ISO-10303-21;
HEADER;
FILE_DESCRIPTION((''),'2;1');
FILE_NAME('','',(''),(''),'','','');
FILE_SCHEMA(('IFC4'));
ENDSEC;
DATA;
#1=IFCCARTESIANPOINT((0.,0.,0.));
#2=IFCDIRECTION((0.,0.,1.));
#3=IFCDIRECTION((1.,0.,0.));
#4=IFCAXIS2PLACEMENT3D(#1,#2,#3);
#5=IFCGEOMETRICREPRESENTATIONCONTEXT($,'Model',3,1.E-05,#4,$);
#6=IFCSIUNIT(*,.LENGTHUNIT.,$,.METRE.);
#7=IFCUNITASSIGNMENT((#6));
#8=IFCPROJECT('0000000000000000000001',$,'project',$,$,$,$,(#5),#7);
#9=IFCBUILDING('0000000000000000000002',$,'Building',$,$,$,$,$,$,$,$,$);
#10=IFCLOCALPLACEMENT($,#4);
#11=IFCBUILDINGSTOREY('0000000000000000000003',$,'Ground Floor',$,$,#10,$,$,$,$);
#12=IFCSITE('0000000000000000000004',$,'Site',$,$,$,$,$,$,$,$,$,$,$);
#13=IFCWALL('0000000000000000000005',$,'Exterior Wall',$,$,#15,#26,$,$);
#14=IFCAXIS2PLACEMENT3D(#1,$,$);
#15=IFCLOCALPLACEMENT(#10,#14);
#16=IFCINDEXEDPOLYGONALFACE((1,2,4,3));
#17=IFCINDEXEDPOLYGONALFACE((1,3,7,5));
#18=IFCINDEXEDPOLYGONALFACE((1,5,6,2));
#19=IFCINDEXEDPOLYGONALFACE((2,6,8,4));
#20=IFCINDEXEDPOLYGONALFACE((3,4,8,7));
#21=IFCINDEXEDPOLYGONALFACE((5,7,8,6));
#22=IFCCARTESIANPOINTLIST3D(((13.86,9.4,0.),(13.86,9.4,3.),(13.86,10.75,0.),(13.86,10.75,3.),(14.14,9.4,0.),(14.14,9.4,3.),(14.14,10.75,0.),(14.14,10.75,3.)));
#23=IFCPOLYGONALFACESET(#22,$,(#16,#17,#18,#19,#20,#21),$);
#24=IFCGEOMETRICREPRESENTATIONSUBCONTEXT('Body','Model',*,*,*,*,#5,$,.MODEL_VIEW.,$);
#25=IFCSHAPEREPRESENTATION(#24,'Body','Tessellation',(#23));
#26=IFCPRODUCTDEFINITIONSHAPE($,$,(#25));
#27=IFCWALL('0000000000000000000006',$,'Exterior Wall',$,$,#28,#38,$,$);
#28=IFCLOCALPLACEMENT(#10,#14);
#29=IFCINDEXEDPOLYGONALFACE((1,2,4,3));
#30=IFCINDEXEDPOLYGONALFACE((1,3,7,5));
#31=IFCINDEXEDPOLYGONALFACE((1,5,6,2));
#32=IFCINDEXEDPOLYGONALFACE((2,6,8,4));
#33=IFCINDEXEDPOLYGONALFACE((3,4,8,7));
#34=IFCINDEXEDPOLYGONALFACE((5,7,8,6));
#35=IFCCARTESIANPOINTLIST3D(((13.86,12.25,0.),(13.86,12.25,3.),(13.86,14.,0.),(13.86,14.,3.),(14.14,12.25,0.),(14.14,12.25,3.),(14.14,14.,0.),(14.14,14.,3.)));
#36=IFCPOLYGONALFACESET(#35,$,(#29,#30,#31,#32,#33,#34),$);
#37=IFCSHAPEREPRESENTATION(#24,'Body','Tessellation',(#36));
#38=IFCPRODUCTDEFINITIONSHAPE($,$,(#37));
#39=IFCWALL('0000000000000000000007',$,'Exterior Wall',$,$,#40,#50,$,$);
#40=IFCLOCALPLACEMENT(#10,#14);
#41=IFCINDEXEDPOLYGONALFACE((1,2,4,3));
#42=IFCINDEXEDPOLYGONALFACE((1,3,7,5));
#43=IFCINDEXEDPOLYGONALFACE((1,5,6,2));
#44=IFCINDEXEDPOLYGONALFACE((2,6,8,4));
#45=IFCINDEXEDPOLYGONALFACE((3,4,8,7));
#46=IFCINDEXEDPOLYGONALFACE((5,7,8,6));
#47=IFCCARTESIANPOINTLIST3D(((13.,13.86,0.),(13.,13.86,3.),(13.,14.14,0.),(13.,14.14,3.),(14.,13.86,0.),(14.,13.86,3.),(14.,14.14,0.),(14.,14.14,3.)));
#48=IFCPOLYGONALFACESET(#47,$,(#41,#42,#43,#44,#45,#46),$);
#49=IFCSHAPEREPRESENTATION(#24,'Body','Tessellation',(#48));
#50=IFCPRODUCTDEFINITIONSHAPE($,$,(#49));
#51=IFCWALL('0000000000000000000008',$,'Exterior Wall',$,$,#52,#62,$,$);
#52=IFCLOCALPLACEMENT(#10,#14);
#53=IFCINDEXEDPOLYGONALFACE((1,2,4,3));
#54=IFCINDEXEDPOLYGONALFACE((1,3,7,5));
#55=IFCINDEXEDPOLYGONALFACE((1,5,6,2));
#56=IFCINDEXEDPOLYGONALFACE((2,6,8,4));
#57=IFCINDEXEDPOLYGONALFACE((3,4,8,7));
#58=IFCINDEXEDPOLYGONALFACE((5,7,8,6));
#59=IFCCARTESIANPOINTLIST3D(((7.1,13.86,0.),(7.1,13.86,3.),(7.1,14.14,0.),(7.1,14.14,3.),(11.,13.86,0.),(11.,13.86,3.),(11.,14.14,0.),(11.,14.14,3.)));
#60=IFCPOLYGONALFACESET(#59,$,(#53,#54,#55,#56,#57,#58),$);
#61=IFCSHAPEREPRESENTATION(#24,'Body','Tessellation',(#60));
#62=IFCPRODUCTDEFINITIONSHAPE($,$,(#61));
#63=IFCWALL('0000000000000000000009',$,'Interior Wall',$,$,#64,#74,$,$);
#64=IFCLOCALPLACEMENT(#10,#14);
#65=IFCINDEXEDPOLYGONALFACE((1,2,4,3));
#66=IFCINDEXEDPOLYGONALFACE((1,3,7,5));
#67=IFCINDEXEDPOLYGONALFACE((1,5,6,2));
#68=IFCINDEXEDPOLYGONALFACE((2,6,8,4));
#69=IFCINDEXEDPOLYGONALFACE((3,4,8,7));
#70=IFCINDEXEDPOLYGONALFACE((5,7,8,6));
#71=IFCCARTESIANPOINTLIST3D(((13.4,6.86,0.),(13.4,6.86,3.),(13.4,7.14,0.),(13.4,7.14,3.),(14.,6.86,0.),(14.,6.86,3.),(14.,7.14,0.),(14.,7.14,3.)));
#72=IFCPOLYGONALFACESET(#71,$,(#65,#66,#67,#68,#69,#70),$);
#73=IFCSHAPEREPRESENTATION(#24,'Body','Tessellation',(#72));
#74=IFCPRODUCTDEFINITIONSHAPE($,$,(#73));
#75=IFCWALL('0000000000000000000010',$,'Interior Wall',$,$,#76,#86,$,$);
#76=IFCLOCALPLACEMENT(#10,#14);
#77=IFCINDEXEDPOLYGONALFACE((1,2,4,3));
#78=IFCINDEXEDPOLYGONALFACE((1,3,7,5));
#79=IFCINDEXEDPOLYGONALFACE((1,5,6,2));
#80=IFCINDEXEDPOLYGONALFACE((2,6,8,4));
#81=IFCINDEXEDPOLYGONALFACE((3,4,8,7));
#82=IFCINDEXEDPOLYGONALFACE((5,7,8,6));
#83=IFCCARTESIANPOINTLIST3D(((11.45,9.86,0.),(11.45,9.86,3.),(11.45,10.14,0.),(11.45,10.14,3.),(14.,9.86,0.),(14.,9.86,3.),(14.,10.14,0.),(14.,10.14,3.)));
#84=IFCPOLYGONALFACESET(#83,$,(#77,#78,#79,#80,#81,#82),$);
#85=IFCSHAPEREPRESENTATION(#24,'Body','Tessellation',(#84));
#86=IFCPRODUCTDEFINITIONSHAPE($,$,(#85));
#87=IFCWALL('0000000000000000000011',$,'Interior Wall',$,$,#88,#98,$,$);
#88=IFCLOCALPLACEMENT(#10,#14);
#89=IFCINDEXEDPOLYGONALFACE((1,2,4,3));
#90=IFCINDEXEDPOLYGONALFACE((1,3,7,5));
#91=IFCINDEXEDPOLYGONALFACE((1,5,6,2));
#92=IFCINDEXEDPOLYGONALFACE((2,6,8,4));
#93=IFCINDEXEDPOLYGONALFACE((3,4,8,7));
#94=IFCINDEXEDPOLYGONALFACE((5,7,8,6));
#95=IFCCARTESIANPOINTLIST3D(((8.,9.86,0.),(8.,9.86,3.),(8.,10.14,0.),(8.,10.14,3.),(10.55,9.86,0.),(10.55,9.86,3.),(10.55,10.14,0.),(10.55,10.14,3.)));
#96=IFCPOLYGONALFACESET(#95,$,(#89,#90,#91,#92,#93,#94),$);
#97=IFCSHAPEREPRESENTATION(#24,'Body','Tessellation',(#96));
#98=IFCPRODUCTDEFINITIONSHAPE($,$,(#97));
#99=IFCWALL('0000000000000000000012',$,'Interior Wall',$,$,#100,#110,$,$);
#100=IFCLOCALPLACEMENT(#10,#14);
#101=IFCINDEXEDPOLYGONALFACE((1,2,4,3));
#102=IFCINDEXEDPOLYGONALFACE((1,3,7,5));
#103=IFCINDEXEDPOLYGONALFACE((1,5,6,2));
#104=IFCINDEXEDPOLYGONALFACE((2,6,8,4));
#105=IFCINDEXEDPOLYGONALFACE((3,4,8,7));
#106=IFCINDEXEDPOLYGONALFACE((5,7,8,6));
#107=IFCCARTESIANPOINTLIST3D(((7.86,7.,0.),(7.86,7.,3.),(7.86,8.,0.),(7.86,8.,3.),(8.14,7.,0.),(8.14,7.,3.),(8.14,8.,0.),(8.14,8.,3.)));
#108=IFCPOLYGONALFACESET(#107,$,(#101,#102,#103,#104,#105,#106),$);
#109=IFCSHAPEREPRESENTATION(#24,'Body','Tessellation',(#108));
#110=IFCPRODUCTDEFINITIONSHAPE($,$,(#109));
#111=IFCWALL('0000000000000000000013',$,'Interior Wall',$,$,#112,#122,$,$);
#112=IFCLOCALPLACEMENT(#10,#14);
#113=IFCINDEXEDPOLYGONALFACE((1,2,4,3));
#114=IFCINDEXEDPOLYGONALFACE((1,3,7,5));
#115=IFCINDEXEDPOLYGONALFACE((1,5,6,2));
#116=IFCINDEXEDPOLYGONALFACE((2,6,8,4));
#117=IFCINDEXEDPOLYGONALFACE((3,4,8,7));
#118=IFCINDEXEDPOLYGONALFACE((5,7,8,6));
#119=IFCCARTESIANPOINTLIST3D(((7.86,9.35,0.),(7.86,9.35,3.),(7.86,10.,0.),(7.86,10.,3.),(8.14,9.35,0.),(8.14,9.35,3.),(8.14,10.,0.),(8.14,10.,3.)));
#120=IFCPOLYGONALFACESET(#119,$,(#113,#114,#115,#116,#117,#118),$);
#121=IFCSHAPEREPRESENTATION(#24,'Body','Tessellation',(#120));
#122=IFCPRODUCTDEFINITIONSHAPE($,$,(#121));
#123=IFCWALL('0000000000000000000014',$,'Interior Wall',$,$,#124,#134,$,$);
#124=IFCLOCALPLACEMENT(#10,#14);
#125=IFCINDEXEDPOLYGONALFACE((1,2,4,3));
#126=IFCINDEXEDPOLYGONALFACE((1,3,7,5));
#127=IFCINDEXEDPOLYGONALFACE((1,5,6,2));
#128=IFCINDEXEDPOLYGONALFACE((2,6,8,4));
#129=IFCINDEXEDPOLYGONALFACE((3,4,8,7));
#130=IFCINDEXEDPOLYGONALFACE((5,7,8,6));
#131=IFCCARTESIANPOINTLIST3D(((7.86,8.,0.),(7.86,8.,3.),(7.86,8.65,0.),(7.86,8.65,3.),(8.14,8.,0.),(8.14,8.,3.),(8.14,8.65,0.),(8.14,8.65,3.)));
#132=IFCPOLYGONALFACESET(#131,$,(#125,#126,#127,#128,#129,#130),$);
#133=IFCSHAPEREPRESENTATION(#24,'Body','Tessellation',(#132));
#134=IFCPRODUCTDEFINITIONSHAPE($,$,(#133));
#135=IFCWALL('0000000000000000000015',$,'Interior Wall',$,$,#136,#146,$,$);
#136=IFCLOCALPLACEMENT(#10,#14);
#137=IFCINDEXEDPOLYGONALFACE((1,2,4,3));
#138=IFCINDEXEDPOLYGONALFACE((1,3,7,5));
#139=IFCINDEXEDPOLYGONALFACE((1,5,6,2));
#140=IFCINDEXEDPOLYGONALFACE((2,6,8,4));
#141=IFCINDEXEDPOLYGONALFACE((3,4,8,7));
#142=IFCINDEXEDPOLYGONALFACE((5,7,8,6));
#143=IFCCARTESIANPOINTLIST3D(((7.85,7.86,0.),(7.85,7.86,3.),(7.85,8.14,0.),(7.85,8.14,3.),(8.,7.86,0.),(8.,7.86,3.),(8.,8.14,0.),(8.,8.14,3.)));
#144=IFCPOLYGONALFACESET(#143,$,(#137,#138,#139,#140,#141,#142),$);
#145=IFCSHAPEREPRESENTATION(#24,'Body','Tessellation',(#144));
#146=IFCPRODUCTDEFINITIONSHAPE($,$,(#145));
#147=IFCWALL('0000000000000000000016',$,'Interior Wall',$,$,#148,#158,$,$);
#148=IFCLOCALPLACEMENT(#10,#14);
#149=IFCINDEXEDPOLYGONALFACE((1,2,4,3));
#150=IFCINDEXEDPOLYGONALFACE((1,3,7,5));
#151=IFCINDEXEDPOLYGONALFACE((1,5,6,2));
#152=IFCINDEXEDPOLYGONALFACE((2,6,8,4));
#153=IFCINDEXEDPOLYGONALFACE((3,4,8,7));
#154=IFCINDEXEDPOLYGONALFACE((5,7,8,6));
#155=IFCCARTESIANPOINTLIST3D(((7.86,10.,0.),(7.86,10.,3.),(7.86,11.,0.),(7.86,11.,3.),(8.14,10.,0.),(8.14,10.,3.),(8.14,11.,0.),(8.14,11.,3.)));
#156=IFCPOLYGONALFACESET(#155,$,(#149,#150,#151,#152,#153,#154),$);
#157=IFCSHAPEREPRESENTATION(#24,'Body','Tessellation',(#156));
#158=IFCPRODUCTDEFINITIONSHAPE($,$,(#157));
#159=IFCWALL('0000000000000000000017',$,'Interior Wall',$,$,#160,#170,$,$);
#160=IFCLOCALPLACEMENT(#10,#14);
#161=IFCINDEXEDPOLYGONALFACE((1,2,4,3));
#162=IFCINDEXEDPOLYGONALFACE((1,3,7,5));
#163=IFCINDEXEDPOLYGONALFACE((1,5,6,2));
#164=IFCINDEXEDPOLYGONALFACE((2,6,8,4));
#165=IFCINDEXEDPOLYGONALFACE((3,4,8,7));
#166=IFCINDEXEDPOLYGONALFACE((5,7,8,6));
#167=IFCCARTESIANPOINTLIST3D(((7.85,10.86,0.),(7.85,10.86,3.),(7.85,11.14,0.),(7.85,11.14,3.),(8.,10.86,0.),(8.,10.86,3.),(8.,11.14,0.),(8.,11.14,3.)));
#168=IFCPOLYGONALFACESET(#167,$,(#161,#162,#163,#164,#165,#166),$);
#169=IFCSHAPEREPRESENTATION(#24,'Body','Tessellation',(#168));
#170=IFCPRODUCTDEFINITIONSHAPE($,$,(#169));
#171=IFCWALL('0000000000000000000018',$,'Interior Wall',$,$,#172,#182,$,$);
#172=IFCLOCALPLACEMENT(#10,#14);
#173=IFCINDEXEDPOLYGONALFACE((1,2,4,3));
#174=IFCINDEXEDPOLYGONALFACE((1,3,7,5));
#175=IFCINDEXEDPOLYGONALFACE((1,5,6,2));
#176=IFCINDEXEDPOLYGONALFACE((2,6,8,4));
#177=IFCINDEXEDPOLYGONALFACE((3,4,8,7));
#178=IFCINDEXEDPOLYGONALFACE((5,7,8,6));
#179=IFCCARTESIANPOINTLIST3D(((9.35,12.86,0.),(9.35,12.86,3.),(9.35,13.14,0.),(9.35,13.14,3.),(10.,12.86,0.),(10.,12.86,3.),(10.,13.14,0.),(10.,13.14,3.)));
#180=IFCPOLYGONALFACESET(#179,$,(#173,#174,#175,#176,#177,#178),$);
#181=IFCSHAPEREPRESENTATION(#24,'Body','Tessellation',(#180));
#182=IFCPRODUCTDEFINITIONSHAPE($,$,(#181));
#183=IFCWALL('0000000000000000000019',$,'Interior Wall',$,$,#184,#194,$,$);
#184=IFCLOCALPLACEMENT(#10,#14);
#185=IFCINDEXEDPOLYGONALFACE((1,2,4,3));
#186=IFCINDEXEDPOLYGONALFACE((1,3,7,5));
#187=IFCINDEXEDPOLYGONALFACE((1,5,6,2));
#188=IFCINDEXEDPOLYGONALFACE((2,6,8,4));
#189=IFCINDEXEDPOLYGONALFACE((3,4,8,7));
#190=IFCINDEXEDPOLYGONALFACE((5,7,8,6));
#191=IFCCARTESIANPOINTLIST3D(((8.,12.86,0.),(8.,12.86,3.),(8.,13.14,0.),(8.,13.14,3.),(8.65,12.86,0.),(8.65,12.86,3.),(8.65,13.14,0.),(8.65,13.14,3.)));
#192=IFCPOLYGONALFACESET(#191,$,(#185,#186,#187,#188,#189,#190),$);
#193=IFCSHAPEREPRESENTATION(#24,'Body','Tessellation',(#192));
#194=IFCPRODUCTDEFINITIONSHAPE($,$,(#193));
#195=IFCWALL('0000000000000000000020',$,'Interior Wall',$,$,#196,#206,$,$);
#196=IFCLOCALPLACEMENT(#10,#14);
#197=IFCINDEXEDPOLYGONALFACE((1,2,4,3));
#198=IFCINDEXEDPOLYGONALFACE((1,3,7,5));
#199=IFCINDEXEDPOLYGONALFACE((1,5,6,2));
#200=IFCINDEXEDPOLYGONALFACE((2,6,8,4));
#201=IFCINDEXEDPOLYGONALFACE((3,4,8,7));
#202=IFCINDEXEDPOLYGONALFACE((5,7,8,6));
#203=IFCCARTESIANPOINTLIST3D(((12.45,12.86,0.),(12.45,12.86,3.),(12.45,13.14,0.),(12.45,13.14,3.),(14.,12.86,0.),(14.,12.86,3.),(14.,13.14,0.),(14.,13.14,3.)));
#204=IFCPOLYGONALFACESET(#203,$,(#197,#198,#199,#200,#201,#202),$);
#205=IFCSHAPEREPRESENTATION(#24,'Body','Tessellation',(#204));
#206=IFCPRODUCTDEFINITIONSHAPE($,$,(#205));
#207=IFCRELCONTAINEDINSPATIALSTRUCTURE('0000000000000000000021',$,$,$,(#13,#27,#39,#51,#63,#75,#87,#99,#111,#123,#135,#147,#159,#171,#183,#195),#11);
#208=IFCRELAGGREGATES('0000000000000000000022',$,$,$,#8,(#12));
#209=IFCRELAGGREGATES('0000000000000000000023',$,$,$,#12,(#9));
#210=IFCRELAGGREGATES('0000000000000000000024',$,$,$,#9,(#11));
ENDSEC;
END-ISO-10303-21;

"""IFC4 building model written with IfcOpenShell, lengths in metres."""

from ifc_helpers import new_model, si_unit, frame, origin_with_axes, place, context, subcontext, project, spatial, indexed_curve, outline, extrude, element, save


model = new_model("IFC4")

# Units and contexts
model_context = context("Model", 3, precision=1e-05, world=origin_with_axes())
body_context = subcontext(model_context, "Body", "Model", "MODEL_VIEW")
ifc_project = project(units=[si_unit("LENGTHUNIT", "METRE")], contexts=[model_context])

# Site, building, storey
site = spatial("IfcSite", under=ifc_project, Name="Site")
building = spatial("IfcBuilding", under=site, Name="Building")
storey_placement = place(None, origin_with_axes())
storey = spatial("IfcBuildingStorey", under=building, at=storey_placement, Name="Ground Floor")

# Walls
wall_1_placement = place(storey_placement, frame((14.0, 9.4, 0.0), z_axis=(0.0, 0.0, 1.0), x_axis=(0.0, 1.0, 0.0)))
element("IfcWall", 1, at=wall_1_placement, inside=storey, Name="Exterior Wall", context=body_context, shape_type="SweptSolid", body=[
    extrude(outline(indexed_curve([(0.0, 0.0), (0.0, 0.28), (1.35, 0.28), (1.35, 0.0), (0.0, 0.0)], self_intersect=False)), frame((0.0, -0.14, 0.0), z_axis=(0.0, 0.0, 1.0), x_axis=(1.0, 0.0, 0.0)), (0.0, 0.0, 1.0), 3.0),
])
wall_2_placement = place(storey_placement, frame((14.0, 12.25, 0.0), z_axis=(0.0, 0.0, 1.0), x_axis=(0.0, 1.0, 0.0)))
element("IfcWall", 2, at=wall_2_placement, inside=storey, Name="Exterior Wall", context=body_context, shape_type="SweptSolid", body=[
    extrude(outline(indexed_curve([(0.0, 0.0), (0.0, 0.28), (1.75, 0.28), (1.75, 0.0), (0.0, 0.0)], self_intersect=False)), frame((0.0, -0.14, 0.0), z_axis=(0.0, 0.0, 1.0), x_axis=(1.0, 0.0, 0.0)), (0.0, 0.0, 1.0), 3.0),
])
wall_3_placement = place(storey_placement, frame((14.0, 14.0, 0.0), z_axis=(0.0, 0.0, 1.0), x_axis=(-1.0, 0.0, 0.0)))
element("IfcWall", 3, at=wall_3_placement, inside=storey, Name="Exterior Wall", context=body_context, shape_type="SweptSolid", body=[
    extrude(outline(indexed_curve([(0.0, 0.0), (0.0, 0.28), (1.0, 0.28), (1.0, 0.0), (0.0, 0.0)], self_intersect=False)), frame((0.0, -0.14, 0.0), z_axis=(0.0, 0.0, 1.0), x_axis=(1.0, 0.0, 0.0)), (0.0, 0.0, 1.0), 3.0),
])
wall_4_placement = place(storey_placement, frame((11.0, 14.0, 0.0), z_axis=(0.0, 0.0, 1.0), x_axis=(-1.0, 0.0, 0.0)))
element("IfcWall", 4, at=wall_4_placement, inside=storey, Name="Exterior Wall", context=body_context, shape_type="SweptSolid", body=[
    extrude(outline(indexed_curve([(0.0, 0.0), (0.0, 0.28), (3.9, 0.28), (3.9, 0.0), (0.0, 0.0)], self_intersect=False)), frame((0.0, -0.14, 0.0), z_axis=(0.0, 0.0, 1.0), x_axis=(1.0, 0.0, 0.0)), (0.0, 0.0, 1.0), 3.0),
])
wall_5_placement = place(storey_placement, frame((14.0, 7.0, 0.0), z_axis=(0.0, 0.0, 1.0), x_axis=(-1.0, 0.0, 0.0)))
element("IfcWall", 5, at=wall_5_placement, inside=storey, Name="Interior Wall", context=body_context, shape_type="SweptSolid", body=[
    extrude(outline(indexed_curve([(0.0, 0.0), (0.0, 0.28), (0.6, 0.28), (0.6, 0.0), (0.0, 0.0)], self_intersect=False)), frame((0.0, -0.14, 0.0), z_axis=(0.0, 0.0, 1.0), x_axis=(1.0, 0.0, 0.0)), (0.0, 0.0, 1.0), 3.0),
])
for number, where, z_axis, x_axis, name in (
    (6, (14.0, 10.0, 0.0), (0.0, 0.0, 1.0), (-1.0, 0.0, 0.0), "Interior Wall"),
    (7, (10.55, 10.0, 0.0), (0.0, 0.0, 1.0), (-1.0, 0.0, 0.0), "Interior Wall"),
):
    element("IfcWall", number, at=place(storey_placement, frame(where, z_axis=z_axis, x_axis=x_axis)), inside=storey, Name=name, context=body_context, shape_type="SweptSolid", body=[
        extrude(outline(indexed_curve([(0.0, 0.0), (0.0, 0.28), (2.55, 0.28), (2.55, 0.0), (0.0, 0.0)], self_intersect=False)), frame((0.0, -0.14, 0.0), z_axis=(0.0, 0.0, 1.0), x_axis=(1.0, 0.0, 0.0)), (0.0, 0.0, 1.0), 3.0),
    ])
wall_6_placement = place(storey_placement, frame((8.0, 8.0, 0.0), z_axis=(0.0, 0.0, 1.0), x_axis=(0.0, -1.0, 0.0)))
element("IfcWall", 8, at=wall_6_placement, inside=storey, Name="Interior Wall", context=body_context, shape_type="SweptSolid", body=[
    extrude(outline(indexed_curve([(0.0, 0.0), (0.0, 0.28), (1.0, 0.28), (1.0, 0.0), (0.0, 0.0)], self_intersect=False)), frame((0.0, -0.14, 0.0), z_axis=(0.0, 0.0, 1.0), x_axis=(1.0, 0.0, 0.0)), (0.0, 0.0, 1.0), 3.0),
])
for number, where, z_axis, x_axis, name in (
    (9, (8.0, 10.0, 0.0), (0.0, 0.0, 1.0), (0.0, -1.0, 0.0), "Interior Wall"),
    (10, (8.0, 8.65, 0.0), (0.0, 0.0, 1.0), (0.0, -1.0, 0.0), "Interior Wall"),
):
    element("IfcWall", number, at=place(storey_placement, frame(where, z_axis=z_axis, x_axis=x_axis)), inside=storey, Name=name, context=body_context, shape_type="SweptSolid", body=[
        extrude(outline(indexed_curve([(0.0, 0.0), (0.0, 0.28), (0.65, 0.28), (0.65, 0.0), (0.0, 0.0)], self_intersect=False)), frame((0.0, -0.14, 0.0), z_axis=(0.0, 0.0, 1.0), x_axis=(1.0, 0.0, 0.0)), (0.0, 0.0, 1.0), 3.0),
    ])
wall_7_placement = place(storey_placement, frame((8.0, 8.0, 0.0), z_axis=(0.0, 0.0, 1.0), x_axis=(-1.0, 0.0, 0.0)))
element("IfcWall", 11, at=wall_7_placement, inside=storey, Name="Interior Wall", context=body_context, shape_type="SweptSolid", body=[
    extrude(outline(indexed_curve([(0.0, 0.0), (0.0, 0.28), (0.15, 0.28), (0.15, 0.0), (0.0, 0.0)], self_intersect=False)), frame((0.0, -0.14, 0.0), z_axis=(0.0, 0.0, 1.0), x_axis=(1.0, 0.0, 0.0)), (0.0, 0.0, 1.0), 3.0),
])
wall_8_placement = place(storey_placement, frame((8.0, 10.0, 0.0), z_axis=(0.0, 0.0, 1.0), x_axis=(0.0, 1.0, 0.0)))
element("IfcWall", 12, at=wall_8_placement, inside=storey, Name="Interior Wall", context=body_context, shape_type="SweptSolid", body=[
    extrude(outline(indexed_curve([(0.0, 0.0), (0.0, 0.28), (1.0, 0.28), (1.0, 0.0), (0.0, 0.0)], self_intersect=False)), frame((0.0, -0.14, 0.0), z_axis=(0.0, 0.0, 1.0), x_axis=(1.0, 0.0, 0.0)), (0.0, 0.0, 1.0), 3.0),
])
wall_9_placement = place(storey_placement, frame((8.0, 11.0, 0.0), z_axis=(0.0, 0.0, 1.0), x_axis=(-1.0, 0.0, 0.0)))
element("IfcWall", 13, at=wall_9_placement, inside=storey, Name="Interior Wall", context=body_context, shape_type="SweptSolid", body=[
    extrude(outline(indexed_curve([(0.0, 0.0), (0.0, 0.28), (0.15, 0.28), (0.15, 0.0), (0.0, 0.0)], self_intersect=False)), frame((0.0, -0.14, 0.0), z_axis=(0.0, 0.0, 1.0), x_axis=(1.0, 0.0, 0.0)), (0.0, 0.0, 1.0), 3.0),
])
for number, where, z_axis, x_axis, name in (
    (14, (10.0, 13.0, 0.0), (0.0, 0.0, 1.0), (-1.0, 0.0, 0.0), "Interior Wall"),
    (15, (8.65, 13.0, 0.0), (0.0, 0.0, 1.0), (-1.0, 0.0, 0.0), "Interior Wall"),
):
    element("IfcWall", number, at=place(storey_placement, frame(where, z_axis=z_axis, x_axis=x_axis)), inside=storey, Name=name, context=body_context, shape_type="SweptSolid", body=[
        extrude(outline(indexed_curve([(0.0, 0.0), (0.0, 0.28), (0.65, 0.28), (0.65, 0.0), (0.0, 0.0)], self_intersect=False)), frame((0.0, -0.14, 0.0), z_axis=(0.0, 0.0, 1.0), x_axis=(1.0, 0.0, 0.0)), (0.0, 0.0, 1.0), 3.0),
    ])
for number, where, z_axis, x_axis, name in (
    (16, (14.0, 13.0, 0.0), (0.0, 0.0, 1.0), (-1.0, 0.0, 0.0), "Interior Wall"),
):
    element("IfcWall", number, at=place(storey_placement, frame(where, z_axis=z_axis, x_axis=x_axis)), inside=storey, Name=name, context=body_context, shape_type="SweptSolid", body=[
        extrude(outline(indexed_curve([(0.0, 0.0), (0.0, 0.28), (1.55, 0.28), (1.55, 0.0), (0.0, 0.0)], self_intersect=False)), frame((0.0, -0.14, 0.0), z_axis=(0.0, 0.0, 1.0), x_axis=(1.0, 0.0, 0.0)), (0.0, 0.0, 1.0), 3.0),
    ])

save(model, "model.ifc")
